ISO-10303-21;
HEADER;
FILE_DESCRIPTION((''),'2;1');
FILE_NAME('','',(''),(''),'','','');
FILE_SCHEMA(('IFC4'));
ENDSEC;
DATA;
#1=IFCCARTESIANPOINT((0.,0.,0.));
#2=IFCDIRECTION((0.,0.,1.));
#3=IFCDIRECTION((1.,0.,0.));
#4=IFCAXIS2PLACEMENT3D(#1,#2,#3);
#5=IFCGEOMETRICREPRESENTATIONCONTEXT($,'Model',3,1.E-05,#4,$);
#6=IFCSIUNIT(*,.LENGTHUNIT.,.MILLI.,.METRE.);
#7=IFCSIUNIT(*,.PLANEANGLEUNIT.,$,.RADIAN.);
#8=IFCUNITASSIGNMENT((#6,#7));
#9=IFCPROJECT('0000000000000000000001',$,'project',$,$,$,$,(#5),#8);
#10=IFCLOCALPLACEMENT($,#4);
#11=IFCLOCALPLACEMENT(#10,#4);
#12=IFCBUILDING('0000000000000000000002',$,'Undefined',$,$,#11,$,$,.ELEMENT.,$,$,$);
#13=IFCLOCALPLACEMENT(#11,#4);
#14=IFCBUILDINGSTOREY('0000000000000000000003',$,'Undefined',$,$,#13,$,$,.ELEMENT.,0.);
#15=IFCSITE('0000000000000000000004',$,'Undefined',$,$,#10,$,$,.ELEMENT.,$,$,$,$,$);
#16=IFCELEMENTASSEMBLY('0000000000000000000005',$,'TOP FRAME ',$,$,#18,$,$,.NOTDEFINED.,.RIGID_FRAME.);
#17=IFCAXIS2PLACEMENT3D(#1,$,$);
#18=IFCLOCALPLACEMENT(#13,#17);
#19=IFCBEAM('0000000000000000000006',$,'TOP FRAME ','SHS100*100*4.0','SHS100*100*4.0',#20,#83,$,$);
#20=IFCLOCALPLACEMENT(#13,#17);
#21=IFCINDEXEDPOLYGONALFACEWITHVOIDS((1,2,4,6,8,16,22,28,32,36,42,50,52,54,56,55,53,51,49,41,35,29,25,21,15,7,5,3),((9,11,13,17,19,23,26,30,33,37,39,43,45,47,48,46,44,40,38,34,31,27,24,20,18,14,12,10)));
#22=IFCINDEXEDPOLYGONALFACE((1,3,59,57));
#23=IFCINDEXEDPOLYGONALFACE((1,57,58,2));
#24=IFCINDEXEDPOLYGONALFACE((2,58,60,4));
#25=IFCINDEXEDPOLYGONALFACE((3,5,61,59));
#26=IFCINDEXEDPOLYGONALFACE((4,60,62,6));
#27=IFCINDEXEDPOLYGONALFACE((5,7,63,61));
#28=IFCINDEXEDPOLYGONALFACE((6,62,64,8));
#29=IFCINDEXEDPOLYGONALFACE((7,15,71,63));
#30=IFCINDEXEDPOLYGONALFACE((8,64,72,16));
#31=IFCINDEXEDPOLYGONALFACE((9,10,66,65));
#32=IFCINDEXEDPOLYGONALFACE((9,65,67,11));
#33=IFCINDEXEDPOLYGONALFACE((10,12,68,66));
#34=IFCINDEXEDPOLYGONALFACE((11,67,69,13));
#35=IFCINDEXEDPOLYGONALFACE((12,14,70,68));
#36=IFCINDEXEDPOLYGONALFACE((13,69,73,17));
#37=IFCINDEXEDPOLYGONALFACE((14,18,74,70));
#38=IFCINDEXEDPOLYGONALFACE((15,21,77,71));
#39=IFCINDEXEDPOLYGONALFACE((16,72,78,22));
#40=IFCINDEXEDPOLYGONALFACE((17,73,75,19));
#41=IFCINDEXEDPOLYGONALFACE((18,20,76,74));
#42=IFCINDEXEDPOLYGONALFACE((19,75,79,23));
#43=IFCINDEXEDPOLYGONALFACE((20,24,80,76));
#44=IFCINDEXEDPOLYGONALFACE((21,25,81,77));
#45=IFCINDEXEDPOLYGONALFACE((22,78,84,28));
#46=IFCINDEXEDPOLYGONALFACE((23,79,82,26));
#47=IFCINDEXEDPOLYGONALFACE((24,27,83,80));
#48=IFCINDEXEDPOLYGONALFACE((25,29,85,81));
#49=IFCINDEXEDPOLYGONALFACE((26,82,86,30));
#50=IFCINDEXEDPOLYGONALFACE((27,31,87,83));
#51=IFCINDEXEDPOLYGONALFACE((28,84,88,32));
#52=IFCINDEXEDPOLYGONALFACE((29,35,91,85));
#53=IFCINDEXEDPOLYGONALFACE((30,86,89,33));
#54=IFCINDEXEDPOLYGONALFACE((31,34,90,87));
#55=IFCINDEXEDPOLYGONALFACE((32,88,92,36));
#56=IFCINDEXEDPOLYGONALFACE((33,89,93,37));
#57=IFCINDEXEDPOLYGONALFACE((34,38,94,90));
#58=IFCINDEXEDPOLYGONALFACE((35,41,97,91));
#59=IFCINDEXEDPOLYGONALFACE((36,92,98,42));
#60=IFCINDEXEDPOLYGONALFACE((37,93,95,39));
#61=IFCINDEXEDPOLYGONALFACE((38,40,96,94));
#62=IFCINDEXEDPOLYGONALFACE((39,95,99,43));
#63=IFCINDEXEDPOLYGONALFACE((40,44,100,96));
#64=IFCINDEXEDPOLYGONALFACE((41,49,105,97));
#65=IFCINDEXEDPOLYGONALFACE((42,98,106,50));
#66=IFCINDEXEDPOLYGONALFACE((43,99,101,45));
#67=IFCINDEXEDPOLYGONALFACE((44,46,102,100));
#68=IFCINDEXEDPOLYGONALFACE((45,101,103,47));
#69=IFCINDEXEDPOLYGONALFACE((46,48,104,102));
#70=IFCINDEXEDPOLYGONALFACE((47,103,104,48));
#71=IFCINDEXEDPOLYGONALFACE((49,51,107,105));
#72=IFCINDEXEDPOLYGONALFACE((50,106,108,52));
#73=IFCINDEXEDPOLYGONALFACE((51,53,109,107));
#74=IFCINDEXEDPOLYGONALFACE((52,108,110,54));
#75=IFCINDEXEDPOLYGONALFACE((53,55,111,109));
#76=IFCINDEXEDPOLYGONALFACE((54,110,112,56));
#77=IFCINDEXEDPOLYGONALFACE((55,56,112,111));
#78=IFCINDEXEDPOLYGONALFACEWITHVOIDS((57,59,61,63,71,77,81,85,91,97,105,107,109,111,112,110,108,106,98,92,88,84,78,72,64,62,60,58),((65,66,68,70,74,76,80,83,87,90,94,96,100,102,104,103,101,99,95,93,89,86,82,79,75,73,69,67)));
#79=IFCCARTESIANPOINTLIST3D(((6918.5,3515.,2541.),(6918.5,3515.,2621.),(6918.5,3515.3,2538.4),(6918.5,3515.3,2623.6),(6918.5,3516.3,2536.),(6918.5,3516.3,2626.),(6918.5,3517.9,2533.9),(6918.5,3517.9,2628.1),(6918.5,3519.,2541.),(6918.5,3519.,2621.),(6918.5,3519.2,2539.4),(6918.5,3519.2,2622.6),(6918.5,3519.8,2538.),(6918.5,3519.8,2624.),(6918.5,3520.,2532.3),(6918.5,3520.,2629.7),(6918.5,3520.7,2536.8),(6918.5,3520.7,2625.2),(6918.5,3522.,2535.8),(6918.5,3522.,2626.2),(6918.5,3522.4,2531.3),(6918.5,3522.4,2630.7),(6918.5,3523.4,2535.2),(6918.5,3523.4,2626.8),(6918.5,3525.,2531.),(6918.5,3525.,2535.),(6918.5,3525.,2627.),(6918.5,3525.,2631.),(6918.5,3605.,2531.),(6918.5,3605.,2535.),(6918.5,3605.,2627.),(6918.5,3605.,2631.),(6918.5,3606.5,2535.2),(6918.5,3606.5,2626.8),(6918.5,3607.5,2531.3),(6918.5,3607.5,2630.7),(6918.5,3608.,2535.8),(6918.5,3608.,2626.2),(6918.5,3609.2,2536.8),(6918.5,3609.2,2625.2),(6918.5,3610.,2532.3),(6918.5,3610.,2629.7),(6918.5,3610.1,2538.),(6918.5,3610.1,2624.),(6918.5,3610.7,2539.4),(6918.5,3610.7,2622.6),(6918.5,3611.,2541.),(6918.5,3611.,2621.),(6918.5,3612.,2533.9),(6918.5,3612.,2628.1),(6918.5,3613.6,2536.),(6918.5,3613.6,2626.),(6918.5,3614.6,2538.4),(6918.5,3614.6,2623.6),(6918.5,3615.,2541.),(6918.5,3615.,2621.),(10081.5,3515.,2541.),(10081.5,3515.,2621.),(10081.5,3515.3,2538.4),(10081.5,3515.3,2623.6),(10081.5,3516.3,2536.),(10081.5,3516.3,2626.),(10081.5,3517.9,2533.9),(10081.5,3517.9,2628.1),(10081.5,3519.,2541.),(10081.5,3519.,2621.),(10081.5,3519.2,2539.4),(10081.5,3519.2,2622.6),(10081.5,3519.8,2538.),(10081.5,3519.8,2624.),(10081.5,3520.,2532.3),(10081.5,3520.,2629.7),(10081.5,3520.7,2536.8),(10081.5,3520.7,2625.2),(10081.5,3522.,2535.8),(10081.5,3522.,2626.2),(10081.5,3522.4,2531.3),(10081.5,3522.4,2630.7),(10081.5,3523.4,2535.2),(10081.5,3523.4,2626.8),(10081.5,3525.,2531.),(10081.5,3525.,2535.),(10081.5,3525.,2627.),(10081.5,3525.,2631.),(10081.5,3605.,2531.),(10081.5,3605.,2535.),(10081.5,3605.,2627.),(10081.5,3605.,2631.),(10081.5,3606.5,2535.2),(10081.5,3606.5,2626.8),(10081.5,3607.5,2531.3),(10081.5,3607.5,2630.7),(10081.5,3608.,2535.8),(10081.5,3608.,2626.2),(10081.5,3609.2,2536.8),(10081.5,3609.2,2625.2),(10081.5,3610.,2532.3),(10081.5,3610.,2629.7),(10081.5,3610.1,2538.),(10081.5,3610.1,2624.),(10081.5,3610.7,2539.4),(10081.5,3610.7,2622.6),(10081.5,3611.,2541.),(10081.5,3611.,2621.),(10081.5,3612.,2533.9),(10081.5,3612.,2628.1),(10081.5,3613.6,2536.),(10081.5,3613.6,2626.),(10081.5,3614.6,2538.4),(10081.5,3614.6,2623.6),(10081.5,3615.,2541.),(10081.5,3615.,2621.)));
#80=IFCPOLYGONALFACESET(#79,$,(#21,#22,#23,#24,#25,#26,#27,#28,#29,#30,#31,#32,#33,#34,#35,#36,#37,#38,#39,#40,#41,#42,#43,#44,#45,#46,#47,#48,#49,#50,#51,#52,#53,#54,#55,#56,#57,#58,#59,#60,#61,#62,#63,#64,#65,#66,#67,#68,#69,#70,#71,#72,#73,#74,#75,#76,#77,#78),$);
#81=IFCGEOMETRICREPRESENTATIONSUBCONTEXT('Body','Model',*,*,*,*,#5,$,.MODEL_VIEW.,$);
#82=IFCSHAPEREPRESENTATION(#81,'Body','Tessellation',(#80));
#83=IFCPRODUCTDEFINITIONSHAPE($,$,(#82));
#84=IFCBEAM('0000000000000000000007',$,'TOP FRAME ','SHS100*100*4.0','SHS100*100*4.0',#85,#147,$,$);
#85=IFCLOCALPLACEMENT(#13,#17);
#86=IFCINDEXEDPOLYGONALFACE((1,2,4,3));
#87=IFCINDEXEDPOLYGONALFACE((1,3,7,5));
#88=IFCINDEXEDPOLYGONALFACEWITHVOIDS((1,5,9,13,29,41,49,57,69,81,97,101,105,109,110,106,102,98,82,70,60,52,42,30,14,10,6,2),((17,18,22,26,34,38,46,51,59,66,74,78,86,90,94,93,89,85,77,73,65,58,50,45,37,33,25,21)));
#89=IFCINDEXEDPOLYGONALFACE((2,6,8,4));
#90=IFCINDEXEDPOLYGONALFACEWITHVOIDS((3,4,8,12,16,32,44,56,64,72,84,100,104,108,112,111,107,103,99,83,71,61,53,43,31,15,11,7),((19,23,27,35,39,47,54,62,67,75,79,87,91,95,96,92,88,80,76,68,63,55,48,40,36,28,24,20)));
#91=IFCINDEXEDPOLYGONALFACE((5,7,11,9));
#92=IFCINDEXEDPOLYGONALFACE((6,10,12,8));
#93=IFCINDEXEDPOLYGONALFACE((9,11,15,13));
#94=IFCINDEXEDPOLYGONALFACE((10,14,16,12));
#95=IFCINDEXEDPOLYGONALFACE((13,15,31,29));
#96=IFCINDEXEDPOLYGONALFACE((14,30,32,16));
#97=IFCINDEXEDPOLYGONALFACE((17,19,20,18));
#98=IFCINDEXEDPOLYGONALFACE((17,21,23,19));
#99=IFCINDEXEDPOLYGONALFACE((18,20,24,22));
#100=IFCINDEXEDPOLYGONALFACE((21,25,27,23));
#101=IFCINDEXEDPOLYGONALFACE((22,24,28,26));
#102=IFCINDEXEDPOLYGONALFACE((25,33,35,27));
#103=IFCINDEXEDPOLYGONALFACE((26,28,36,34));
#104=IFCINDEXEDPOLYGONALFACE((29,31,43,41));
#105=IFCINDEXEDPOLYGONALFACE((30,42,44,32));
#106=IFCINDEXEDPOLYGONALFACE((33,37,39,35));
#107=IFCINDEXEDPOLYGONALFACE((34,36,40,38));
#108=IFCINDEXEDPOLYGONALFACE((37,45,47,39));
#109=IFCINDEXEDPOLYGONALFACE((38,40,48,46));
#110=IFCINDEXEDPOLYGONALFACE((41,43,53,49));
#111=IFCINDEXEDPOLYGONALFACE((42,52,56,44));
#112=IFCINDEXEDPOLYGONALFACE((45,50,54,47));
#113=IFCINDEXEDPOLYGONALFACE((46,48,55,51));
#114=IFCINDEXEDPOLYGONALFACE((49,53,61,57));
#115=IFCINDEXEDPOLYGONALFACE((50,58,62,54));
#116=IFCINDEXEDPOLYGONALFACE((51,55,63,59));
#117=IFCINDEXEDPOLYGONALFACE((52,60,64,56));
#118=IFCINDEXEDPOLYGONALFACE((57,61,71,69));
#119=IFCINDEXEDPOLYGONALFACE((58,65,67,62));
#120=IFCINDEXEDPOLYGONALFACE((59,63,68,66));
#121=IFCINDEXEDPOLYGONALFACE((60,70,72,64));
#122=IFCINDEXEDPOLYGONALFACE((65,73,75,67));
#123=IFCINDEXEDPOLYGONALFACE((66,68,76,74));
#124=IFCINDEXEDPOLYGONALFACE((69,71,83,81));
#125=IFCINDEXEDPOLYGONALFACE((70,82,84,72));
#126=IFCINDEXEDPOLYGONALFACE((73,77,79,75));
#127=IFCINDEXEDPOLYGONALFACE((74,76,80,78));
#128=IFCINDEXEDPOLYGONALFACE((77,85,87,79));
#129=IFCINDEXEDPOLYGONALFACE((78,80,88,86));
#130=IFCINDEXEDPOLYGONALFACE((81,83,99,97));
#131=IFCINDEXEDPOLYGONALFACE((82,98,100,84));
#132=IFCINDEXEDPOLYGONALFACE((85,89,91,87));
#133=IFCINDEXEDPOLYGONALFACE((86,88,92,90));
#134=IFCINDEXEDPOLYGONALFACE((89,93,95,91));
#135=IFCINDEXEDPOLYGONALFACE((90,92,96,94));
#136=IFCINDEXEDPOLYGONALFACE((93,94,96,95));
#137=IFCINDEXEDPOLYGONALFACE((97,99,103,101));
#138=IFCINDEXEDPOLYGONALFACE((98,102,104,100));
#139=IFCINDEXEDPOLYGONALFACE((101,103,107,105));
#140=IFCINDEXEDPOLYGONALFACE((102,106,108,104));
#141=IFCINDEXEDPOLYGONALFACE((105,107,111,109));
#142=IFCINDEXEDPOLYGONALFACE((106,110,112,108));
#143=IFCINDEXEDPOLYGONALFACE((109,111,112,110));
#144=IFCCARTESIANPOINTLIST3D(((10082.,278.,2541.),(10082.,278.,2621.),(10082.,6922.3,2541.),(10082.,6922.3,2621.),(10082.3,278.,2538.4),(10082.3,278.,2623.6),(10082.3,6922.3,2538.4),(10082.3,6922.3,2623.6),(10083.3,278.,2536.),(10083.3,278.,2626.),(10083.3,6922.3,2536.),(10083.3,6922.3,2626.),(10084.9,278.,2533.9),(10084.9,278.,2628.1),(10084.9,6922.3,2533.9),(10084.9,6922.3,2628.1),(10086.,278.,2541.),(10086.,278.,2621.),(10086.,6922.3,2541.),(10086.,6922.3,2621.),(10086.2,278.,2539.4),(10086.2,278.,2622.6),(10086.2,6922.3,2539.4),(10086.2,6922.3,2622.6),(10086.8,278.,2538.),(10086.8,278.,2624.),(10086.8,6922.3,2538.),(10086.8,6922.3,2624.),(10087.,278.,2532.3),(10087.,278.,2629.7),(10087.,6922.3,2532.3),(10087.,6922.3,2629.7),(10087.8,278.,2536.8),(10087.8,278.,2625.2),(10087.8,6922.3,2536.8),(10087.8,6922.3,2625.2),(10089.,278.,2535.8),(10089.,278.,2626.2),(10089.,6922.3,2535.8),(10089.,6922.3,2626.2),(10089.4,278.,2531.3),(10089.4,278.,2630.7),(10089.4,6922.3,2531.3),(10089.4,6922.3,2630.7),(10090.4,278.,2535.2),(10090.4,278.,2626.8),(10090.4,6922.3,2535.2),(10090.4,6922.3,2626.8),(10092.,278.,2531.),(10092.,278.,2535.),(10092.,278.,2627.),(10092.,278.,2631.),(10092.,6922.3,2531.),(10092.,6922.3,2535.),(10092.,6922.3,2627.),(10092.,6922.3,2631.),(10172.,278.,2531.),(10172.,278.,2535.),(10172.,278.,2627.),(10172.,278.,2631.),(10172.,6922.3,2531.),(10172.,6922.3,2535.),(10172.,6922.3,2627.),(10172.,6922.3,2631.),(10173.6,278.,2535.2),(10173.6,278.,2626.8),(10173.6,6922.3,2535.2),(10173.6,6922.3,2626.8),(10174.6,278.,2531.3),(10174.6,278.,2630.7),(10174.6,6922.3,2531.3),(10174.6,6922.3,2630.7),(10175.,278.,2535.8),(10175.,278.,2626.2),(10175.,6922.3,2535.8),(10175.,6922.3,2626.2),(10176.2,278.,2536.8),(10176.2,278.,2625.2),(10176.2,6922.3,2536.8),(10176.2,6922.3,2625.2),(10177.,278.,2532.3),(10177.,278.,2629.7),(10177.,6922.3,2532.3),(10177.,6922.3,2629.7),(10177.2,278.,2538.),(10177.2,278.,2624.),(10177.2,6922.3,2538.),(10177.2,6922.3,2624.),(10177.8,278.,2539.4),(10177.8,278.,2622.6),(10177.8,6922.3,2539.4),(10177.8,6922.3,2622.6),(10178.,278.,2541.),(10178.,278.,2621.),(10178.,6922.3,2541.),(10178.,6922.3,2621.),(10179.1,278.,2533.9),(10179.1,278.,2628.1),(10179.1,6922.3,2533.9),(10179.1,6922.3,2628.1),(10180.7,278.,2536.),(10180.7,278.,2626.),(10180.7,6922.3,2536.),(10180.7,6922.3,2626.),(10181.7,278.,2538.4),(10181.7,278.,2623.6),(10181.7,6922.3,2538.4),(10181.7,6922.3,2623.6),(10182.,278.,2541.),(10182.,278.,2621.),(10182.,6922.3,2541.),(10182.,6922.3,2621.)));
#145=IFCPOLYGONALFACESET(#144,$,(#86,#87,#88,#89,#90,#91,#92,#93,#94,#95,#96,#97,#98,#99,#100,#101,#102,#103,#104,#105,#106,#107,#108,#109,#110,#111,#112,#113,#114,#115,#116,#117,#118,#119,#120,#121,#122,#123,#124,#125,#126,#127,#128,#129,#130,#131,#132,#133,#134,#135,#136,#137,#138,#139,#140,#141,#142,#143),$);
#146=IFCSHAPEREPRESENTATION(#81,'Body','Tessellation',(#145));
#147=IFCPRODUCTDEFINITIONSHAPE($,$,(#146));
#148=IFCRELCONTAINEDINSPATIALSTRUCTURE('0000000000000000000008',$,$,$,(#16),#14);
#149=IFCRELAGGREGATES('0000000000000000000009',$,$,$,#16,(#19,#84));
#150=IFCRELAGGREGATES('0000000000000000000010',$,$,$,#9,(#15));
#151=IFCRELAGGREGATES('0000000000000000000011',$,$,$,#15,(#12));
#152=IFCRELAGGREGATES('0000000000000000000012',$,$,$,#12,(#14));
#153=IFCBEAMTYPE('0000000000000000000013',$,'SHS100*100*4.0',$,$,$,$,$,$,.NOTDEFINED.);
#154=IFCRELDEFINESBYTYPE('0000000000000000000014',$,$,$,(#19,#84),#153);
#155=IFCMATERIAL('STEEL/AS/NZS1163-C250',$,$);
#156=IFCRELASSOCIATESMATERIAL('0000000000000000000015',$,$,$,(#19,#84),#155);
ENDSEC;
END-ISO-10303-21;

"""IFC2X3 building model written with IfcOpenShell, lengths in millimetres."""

from ifc_helpers import new_model, si_unit, frame, origin_with_axes, origin_2d_with_axis, place, context, subcontext, project, spatial, hollow_rectangle, extrude, material, type_object, element, aggregate, save


model = new_model("IFC2X3")

# Units and contexts
model_context = context("Model", 3, precision=1e-05, world=origin_with_axes())
body_context = subcontext(model_context, "Body", "Model", "MODEL_VIEW")
ifc_project = project(units=[si_unit("LENGTHUNIT", "METRE", prefix="MILLI"), si_unit("PLANEANGLEUNIT", "RADIAN")], contexts=[model_context])

# Site, building, storey
site_placement = place(None, origin_with_axes())
site = spatial("IfcSite", under=ifc_project, at=site_placement, Name="Undefined", CompositionType="ELEMENT")
building_placement = place(site_placement, origin_with_axes())
building = spatial("IfcBuilding", under=site, at=building_placement, Name="Undefined", CompositionType="ELEMENT")
storey_placement = place(building_placement, origin_with_axes())
storey = spatial("IfcBuildingStorey", under=building, at=storey_placement, Name="Undefined", CompositionType="ELEMENT", Elevation=0.0)

# Element assembly, beams
ifc_material_1 = material(Name="STEEL/AS/NZS1163-C250")
beam_type_1 = type_object("IfcBeamType", Name="SHS100*100*4.0", PredefinedType="NOTDEFINED")
assembly_1_placement = place(storey_placement, origin_with_axes())
assembly_1 = element("IfcElementAssembly", 1, at=assembly_1_placement, inside=storey, Name="TOP FRAME ", AssemblyPlace="NOTDEFINED", PredefinedType="RIGID_FRAME")
beam_1_placement = place(assembly_1_placement, frame((10081.5, 3564.9, 2581.0), z_axis=(0.0, 0.0, 1.0), x_axis=(-1.0, 0.0, 0.0)))
beam_1 = element("IfcBeam", 2, at=beam_1_placement, type_object=beam_type_1, material=ifc_material_1, Name="TOP FRAME ", Description="SHS100*100*4.0", ObjectType="SHS100*100*4.0", context=body_context, shape_type="SweptSolid", body=[
    extrude(hollow_rectangle(XDim=100.0, YDim=100.0, WallThickness=4.0, InnerFilletRadius=6.0, OuterFilletRadius=10.0, at=origin_2d_with_axis()), frame((3163.0, 0.0, 0.0), z_axis=(-1.0, 0.0, 0.0), x_axis=(0.0, -1.0, 0.0)), (0.0, 0.0, 1.0), 3163.0),
])
beam_2_placement = place(assembly_1_placement, frame((10132.0, 6922.3, 2581.0), z_axis=(0.0, 0.0, 1.0), x_axis=(0.0, -1.0, 0.0)))
beam_2 = element("IfcBeam", 3, at=beam_2_placement, type_object=beam_type_1, material=ifc_material_1, Name="TOP FRAME ", Description="SHS100*100*4.0", ObjectType="SHS100*100*4.0", context=body_context, shape_type="SweptSolid", body=[
    extrude(hollow_rectangle(XDim=100.0, YDim=100.0, WallThickness=4.0, InnerFilletRadius=6.0, OuterFilletRadius=10.0, at=origin_2d_with_axis()), frame((6644.3, 0.0, 0.0), z_axis=(-1.0, 0.0, 0.0), x_axis=(0.0, -1.0, 0.0)), (0.0, 0.0, 1.0), 6644.3),
])
aggregate(assembly_1, [beam_1, beam_2])

save(model, "model.ifc")
